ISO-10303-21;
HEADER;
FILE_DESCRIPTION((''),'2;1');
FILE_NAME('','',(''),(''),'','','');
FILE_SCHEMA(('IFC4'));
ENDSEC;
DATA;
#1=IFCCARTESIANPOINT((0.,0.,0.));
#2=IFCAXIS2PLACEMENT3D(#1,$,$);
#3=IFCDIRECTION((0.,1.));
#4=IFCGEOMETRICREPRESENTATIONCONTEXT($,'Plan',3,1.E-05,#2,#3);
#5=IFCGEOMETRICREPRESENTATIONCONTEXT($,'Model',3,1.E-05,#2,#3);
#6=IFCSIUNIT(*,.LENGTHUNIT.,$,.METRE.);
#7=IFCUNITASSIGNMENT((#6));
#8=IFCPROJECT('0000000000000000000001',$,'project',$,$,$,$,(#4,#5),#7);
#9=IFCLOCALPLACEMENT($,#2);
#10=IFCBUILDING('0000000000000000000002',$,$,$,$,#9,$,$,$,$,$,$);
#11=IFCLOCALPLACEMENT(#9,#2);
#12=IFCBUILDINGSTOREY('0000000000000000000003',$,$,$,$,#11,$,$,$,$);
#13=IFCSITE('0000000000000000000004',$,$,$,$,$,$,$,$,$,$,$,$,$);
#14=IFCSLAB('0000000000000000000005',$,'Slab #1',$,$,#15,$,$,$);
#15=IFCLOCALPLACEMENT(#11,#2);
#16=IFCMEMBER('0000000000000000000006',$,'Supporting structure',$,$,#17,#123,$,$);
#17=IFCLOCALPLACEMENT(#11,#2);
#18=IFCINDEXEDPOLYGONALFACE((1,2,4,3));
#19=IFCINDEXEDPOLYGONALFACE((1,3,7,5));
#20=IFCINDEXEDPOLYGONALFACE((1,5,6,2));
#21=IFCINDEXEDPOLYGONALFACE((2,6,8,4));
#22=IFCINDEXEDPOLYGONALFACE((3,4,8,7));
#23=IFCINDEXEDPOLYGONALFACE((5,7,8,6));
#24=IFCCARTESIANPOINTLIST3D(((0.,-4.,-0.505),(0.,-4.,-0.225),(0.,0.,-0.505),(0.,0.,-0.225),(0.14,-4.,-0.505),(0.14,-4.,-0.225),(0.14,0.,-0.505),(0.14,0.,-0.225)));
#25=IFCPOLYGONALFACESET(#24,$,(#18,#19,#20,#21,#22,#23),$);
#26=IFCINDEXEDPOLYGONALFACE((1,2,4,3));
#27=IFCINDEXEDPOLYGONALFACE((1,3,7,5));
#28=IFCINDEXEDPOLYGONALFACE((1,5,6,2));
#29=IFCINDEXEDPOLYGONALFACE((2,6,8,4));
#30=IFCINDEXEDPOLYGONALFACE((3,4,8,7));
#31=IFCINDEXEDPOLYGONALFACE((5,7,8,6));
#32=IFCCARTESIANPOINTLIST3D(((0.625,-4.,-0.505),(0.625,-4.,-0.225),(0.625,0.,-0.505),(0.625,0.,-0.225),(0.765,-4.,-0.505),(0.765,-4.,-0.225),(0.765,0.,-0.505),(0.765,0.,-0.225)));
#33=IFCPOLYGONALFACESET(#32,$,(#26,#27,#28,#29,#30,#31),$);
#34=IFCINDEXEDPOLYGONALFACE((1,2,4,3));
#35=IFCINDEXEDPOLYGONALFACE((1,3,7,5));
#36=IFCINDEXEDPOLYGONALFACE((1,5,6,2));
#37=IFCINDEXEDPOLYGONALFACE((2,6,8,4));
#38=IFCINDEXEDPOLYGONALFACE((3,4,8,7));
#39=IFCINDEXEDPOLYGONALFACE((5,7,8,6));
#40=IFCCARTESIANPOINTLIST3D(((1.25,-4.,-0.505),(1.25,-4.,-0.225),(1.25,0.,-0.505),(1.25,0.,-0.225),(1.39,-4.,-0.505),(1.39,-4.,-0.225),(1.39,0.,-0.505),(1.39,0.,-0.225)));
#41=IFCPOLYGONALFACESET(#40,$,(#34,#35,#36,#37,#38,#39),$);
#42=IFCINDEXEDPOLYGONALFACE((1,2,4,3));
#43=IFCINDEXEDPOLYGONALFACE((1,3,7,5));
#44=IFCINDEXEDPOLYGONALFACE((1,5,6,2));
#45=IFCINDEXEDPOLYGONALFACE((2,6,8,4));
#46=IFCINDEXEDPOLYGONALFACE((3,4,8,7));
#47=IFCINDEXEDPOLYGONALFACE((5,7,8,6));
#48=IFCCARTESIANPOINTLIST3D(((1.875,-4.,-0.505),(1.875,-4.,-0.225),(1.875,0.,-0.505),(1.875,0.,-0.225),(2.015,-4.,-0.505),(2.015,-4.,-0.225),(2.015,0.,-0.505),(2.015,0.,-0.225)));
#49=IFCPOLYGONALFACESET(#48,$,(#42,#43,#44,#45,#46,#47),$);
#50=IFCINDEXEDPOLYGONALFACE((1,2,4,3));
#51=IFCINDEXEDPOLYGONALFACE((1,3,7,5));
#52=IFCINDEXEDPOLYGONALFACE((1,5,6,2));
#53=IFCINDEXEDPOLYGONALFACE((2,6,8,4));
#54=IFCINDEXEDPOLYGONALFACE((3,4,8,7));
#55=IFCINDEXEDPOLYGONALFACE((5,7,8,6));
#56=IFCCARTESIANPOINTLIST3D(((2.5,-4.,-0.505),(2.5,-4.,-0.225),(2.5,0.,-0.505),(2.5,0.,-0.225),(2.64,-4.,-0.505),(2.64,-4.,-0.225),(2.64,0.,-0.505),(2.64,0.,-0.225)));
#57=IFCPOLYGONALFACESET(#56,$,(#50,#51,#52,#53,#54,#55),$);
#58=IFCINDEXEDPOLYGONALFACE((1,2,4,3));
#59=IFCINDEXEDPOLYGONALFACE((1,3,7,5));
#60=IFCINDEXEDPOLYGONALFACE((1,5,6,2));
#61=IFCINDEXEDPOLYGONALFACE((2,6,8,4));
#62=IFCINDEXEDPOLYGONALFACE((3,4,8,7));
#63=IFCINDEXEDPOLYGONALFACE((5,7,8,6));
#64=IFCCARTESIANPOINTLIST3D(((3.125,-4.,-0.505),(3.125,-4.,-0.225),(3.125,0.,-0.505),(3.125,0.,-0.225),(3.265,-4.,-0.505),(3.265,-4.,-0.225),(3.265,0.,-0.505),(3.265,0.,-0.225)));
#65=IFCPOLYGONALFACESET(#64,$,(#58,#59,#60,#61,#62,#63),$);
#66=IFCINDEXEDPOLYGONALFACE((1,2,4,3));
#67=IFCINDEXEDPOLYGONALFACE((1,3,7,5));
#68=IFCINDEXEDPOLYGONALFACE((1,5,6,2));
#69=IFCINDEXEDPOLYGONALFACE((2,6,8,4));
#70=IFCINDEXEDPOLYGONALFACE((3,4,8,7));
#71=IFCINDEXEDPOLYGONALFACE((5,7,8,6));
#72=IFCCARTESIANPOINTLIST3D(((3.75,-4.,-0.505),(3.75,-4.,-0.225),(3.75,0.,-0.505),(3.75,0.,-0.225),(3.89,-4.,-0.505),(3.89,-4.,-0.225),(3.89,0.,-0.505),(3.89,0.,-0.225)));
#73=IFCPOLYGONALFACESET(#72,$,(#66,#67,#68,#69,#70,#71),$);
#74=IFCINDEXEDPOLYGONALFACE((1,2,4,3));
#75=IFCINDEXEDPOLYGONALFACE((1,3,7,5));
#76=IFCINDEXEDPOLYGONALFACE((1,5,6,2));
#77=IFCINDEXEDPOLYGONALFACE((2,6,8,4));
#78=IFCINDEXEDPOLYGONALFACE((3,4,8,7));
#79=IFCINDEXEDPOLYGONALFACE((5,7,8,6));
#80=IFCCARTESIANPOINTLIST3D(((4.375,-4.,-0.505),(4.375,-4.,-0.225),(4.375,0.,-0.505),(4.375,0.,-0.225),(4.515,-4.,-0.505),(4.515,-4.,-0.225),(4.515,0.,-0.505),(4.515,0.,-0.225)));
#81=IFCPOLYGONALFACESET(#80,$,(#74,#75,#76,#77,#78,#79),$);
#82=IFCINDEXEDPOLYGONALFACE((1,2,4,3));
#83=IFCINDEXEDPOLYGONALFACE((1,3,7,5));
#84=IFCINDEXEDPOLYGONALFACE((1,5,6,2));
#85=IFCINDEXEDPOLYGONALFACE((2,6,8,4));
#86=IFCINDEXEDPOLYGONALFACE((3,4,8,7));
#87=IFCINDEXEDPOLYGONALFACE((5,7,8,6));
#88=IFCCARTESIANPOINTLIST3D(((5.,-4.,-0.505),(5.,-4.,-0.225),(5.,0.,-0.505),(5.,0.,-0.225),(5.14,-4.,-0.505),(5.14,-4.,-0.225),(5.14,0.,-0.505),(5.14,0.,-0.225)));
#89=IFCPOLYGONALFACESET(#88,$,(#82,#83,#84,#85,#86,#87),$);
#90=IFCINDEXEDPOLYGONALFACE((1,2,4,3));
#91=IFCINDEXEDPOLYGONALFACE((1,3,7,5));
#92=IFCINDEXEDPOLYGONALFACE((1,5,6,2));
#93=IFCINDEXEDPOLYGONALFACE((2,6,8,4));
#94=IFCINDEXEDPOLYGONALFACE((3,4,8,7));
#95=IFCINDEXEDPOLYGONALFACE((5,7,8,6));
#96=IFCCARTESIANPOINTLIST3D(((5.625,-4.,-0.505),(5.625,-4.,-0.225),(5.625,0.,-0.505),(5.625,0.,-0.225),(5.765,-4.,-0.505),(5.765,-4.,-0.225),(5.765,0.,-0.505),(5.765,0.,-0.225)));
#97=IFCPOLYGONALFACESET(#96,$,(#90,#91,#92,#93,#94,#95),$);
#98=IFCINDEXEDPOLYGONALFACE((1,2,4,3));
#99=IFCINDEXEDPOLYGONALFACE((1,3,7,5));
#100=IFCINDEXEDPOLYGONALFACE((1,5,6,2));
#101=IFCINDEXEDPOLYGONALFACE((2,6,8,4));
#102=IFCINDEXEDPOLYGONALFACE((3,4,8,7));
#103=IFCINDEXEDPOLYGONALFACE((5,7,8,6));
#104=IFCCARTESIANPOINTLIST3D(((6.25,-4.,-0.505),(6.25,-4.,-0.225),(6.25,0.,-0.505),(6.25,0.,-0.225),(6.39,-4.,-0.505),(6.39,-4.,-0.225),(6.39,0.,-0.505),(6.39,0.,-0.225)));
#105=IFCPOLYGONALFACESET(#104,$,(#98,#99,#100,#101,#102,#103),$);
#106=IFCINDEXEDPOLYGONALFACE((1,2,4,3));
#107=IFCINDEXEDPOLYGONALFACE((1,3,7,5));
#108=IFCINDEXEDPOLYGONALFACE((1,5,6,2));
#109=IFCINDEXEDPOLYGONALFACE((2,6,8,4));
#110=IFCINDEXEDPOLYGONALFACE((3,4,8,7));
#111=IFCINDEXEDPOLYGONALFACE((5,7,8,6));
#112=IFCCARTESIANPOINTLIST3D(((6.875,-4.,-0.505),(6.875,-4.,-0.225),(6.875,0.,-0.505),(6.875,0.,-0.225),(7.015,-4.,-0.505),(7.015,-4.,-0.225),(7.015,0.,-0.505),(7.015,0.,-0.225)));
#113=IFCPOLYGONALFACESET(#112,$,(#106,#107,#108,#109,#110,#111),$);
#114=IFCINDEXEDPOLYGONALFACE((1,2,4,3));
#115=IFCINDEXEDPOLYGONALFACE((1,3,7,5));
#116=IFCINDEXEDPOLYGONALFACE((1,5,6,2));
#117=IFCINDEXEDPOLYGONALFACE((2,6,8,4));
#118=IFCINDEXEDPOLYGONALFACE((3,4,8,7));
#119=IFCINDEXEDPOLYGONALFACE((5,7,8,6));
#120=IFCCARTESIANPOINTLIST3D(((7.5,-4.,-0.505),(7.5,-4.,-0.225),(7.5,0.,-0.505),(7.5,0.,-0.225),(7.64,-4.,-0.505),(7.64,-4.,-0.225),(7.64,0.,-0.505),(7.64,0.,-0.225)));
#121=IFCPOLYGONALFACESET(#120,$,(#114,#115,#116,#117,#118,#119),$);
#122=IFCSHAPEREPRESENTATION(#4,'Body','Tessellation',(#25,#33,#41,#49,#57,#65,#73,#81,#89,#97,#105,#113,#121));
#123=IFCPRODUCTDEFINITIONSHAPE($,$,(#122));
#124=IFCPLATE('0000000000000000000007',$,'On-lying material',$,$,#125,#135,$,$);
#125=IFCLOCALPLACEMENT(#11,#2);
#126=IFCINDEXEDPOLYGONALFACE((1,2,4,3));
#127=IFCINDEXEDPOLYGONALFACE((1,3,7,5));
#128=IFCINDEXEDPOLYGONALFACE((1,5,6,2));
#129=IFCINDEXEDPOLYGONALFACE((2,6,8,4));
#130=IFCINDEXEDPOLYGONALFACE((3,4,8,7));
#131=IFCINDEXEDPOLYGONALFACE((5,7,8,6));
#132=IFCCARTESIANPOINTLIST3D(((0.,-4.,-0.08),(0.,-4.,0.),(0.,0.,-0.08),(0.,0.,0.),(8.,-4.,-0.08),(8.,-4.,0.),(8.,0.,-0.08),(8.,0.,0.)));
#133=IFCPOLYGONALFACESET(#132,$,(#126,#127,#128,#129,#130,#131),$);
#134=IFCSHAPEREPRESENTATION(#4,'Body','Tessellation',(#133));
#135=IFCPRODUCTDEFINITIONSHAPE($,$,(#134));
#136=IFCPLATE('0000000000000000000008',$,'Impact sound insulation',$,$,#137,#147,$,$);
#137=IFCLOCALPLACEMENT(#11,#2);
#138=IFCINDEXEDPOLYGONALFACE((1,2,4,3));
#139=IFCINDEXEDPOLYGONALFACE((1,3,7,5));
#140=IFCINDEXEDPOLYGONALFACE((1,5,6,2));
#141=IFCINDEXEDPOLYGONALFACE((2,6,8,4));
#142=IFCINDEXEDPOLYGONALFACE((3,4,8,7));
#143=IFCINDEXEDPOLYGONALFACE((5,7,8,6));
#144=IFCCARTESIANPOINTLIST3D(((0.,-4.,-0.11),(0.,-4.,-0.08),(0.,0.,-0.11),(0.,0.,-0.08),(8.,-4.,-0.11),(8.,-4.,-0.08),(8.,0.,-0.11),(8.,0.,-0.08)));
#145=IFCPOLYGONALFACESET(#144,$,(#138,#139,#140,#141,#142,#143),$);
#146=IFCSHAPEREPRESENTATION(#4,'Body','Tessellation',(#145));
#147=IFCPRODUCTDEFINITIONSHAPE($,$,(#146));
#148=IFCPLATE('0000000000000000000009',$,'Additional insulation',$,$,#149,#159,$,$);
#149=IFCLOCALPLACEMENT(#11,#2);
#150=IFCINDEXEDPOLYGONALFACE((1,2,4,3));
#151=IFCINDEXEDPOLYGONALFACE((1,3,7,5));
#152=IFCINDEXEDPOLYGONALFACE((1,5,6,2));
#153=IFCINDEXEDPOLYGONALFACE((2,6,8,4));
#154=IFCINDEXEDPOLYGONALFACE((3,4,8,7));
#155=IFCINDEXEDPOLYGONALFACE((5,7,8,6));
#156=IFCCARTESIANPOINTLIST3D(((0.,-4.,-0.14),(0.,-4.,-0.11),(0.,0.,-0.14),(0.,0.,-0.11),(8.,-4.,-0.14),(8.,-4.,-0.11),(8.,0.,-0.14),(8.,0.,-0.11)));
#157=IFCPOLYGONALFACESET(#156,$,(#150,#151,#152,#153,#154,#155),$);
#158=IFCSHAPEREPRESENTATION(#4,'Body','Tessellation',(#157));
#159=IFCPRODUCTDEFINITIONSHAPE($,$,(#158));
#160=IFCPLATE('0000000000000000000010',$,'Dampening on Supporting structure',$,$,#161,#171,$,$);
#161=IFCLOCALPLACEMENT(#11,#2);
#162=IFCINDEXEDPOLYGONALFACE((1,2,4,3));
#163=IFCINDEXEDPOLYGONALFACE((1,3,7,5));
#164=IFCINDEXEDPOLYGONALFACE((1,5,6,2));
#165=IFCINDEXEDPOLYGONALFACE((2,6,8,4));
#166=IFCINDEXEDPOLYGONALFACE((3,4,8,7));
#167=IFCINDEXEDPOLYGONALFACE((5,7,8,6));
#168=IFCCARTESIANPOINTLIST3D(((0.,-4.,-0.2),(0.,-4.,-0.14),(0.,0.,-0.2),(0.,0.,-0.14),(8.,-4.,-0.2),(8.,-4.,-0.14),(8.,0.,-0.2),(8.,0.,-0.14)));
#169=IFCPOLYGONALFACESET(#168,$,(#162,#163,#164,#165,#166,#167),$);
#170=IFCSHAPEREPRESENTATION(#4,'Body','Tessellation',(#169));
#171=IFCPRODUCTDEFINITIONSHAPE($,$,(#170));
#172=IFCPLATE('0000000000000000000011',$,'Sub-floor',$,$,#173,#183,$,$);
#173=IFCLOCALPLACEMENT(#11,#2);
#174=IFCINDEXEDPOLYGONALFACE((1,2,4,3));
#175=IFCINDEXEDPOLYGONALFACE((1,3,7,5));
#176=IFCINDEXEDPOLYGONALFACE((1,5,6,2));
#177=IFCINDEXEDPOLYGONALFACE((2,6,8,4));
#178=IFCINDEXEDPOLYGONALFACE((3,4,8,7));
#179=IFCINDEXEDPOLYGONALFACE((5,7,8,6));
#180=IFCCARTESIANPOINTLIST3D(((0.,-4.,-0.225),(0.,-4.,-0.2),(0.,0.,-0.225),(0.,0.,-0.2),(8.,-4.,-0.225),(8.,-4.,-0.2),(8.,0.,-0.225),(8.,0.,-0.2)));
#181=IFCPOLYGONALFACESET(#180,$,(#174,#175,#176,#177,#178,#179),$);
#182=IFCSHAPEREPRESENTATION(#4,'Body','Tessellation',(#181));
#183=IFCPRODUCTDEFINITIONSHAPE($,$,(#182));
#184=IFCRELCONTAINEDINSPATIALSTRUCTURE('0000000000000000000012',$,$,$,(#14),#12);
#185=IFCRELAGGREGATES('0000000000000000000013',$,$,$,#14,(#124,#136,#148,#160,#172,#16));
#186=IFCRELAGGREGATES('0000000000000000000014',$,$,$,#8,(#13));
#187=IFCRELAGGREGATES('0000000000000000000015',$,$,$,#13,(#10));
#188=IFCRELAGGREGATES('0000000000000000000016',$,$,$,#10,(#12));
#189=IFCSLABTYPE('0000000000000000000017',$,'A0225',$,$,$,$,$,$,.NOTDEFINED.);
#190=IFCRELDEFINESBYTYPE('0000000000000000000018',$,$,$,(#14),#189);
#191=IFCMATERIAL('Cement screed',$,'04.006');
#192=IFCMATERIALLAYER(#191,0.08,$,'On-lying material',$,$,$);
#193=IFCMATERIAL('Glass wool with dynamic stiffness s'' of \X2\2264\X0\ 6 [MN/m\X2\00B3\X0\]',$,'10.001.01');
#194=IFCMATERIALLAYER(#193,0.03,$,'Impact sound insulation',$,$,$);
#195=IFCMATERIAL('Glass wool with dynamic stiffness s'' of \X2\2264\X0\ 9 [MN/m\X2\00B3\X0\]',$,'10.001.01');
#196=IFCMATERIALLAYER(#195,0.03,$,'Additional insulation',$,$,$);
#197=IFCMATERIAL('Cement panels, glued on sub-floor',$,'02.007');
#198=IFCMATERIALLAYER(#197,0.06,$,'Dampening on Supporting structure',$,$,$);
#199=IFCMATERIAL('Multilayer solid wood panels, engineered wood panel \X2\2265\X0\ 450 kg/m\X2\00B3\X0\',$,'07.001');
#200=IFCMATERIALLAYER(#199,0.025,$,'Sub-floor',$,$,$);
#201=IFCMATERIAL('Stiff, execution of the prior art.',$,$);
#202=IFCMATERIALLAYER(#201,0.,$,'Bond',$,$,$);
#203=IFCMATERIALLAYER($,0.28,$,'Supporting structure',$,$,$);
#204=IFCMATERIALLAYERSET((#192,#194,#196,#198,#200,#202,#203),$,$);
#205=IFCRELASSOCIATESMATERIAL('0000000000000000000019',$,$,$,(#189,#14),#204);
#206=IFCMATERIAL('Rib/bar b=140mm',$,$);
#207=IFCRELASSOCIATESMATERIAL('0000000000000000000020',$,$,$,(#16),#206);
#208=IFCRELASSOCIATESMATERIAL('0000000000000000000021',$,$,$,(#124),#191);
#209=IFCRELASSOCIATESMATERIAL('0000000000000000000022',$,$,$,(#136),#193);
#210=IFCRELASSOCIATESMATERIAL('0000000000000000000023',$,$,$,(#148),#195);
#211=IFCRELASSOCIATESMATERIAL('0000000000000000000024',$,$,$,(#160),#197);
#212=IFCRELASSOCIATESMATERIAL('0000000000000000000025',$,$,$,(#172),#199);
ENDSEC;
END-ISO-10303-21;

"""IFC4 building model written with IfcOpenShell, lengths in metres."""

from ifc_helpers import new_model, si_unit, direction, frame, frame_2d, origin, origin_with_axes, place, context, project, spatial, rectangle, extrude, material, layer, layer_set, type_object, element, aggregate, save


model = new_model("IFC4")

# Units and contexts
plan_context = context("Plan", 3, precision=1e-05, world=origin(), true_north=direction((0.0, 1.0)))
model_context = context("Model", 3, precision=1e-05, world=origin(), true_north=direction((0.0, 1.0)))
ifc_project = project(units=[si_unit("LENGTHUNIT", "METRE")], contexts=[plan_context, model_context])

# Site, building, storey
site = spatial("IfcSite", under=ifc_project)
building_placement = place(None, origin())
building = spatial("IfcBuilding", under=site, at=building_placement)
storey_placement = place(building_placement, origin())
storey = spatial("IfcBuildingStorey", under=building, at=storey_placement)

# Slab, member, plates
ifc_material_1 = material(Name="Cement screed", Category="04.006")
ifc_layer_1 = layer(ifc_material_1, 0.08, Name="On-lying material")
ifc_material_2 = material(Name="Glass wool with dynamic stiffness s' of ≤ 6 [MN/m³]", Category="10.001.01")
ifc_layer_2 = layer(ifc_material_2, 0.03, Name="Impact sound insulation")
ifc_material_3 = material(Name="Glass wool with dynamic stiffness s' of ≤ 9 [MN/m³]", Category="10.001.01")
ifc_layer_3 = layer(ifc_material_3, 0.03, Name="Additional insulation")
ifc_material_4 = material(Name="Cement panels, glued on sub-floor", Category="02.007")
ifc_layer_4 = layer(ifc_material_4, 0.06, Name="Dampening on Supporting structure")
ifc_material_5 = material(Name="Multilayer solid wood panels, engineered wood panel ≥ 450 kg/m³", Category="07.001")
ifc_layer_5 = layer(ifc_material_5, 0.025, Name="Sub-floor")
ifc_material_6 = material(Name="Stiff, execution of the prior art.")
ifc_layer_6 = layer(ifc_material_6, 0.0, Name="Bond")
ifc_layer_7 = layer(None, 0.28, Name="Supporting structure")
ifc_layer_set = layer_set([ifc_layer_1, ifc_layer_2, ifc_layer_3, ifc_layer_4, ifc_layer_5, ifc_layer_6, ifc_layer_7])
slab_type = type_object("IfcSlabType", Name="A0225", PredefinedType="NOTDEFINED", material=ifc_layer_set)
slab_placement = place(None, frame((0.0, 0.0, 0.0), z_axis=(0.0, 0.0, -1.0), x_axis=(1.0, 0.0, 0.0)))
slab = element("IfcSlab", 1, at=slab_placement, inside=storey, type_object=slab_type, material=ifc_layer_set, Name="Slab #1")
ifc_material_7 = material(Name="Rib/bar b=140mm")
member_placement = place(slab_placement, origin())
member = element("IfcMember", 2, at=member_placement, material=ifc_material_7, Name="Supporting structure", context=plan_context, shape_type="SweptSolid", body=[
    extrude(rectangle(XDim=0.14, YDim=0.28, at=frame_2d((0.07, 0.14), x_axis=(1.0, 0.0))), frame((0.0, 4.0, 0.225), z_axis=(0.0, -1.0, 0.0), x_axis=(1.0, 0.0, 0.0)), (0.0, 0.0, 1.0), 4.0),
    extrude(rectangle(XDim=0.14, YDim=0.28, at=frame_2d((0.07, 0.14), x_axis=(1.0, 0.0))), frame((0.625, 4.0, 0.225), z_axis=(0.0, -1.0, 0.0), x_axis=(1.0, 0.0, 0.0)), (0.0, 0.0, 1.0), 4.0),
    extrude(rectangle(XDim=0.14, YDim=0.28, at=frame_2d((0.07, 0.14), x_axis=(1.0, 0.0))), frame((1.25, 4.0, 0.225), z_axis=(0.0, -1.0, 0.0), x_axis=(1.0, 0.0, 0.0)), (0.0, 0.0, 1.0), 4.0),
    extrude(rectangle(XDim=0.14, YDim=0.28, at=frame_2d((0.07, 0.14), x_axis=(1.0, 0.0))), frame((1.875, 4.0, 0.225), z_axis=(0.0, -1.0, 0.0), x_axis=(1.0, 0.0, 0.0)), (0.0, 0.0, 1.0), 4.0),
    extrude(rectangle(XDim=0.14, YDim=0.28, at=frame_2d((0.07, 0.14), x_axis=(1.0, 0.0))), frame((2.5, 4.0, 0.225), z_axis=(0.0, -1.0, 0.0), x_axis=(1.0, 0.0, 0.0)), (0.0, 0.0, 1.0), 4.0),
    extrude(rectangle(XDim=0.14, YDim=0.28, at=frame_2d((0.07, 0.14), x_axis=(1.0, 0.0))), frame((3.125, 4.0, 0.225), z_axis=(0.0, -1.0, 0.0), x_axis=(1.0, 0.0, 0.0)), (0.0, 0.0, 1.0), 4.0),
    extrude(rectangle(XDim=0.14, YDim=0.28, at=frame_2d((0.07, 0.14), x_axis=(1.0, 0.0))), frame((3.75, 4.0, 0.225), z_axis=(0.0, -1.0, 0.0), x_axis=(1.0, 0.0, 0.0)), (0.0, 0.0, 1.0), 4.0),
    extrude(rectangle(XDim=0.14, YDim=0.28, at=frame_2d((0.07, 0.14), x_axis=(1.0, 0.0))), frame((4.375, 4.0, 0.225), z_axis=(0.0, -1.0, 0.0), x_axis=(1.0, 0.0, 0.0)), (0.0, 0.0, 1.0), 4.0),
    extrude(rectangle(XDim=0.14, YDim=0.28, at=frame_2d((0.07, 0.14), x_axis=(1.0, 0.0))), frame((5.0, 4.0, 0.225), z_axis=(0.0, -1.0, 0.0), x_axis=(1.0, 0.0, 0.0)), (0.0, 0.0, 1.0), 4.0),
    extrude(rectangle(XDim=0.14, YDim=0.28, at=frame_2d((0.07, 0.14), x_axis=(1.0, 0.0))), frame((5.625, 4.0, 0.225), z_axis=(0.0, -1.0, 0.0), x_axis=(1.0, 0.0, 0.0)), (0.0, 0.0, 1.0), 4.0),
    extrude(rectangle(XDim=0.14, YDim=0.28, at=frame_2d((0.07, 0.14), x_axis=(1.0, 0.0))), frame((6.25, 4.0, 0.225), z_axis=(0.0, -1.0, 0.0), x_axis=(1.0, 0.0, 0.0)), (0.0, 0.0, 1.0), 4.0),
    extrude(rectangle(XDim=0.14, YDim=0.28, at=frame_2d((0.07, 0.14), x_axis=(1.0, 0.0))), frame((6.875, 4.0, 0.225), z_axis=(0.0, -1.0, 0.0), x_axis=(1.0, 0.0, 0.0)), (0.0, 0.0, 1.0), 4.0),
    extrude(rectangle(XDim=0.14, YDim=0.28, at=frame_2d((0.07, 0.14), x_axis=(1.0, 0.0))), frame((7.5, 4.0, 0.225), z_axis=(0.0, -1.0, 0.0), x_axis=(1.0, 0.0, 0.0)), (0.0, 0.0, 1.0), 4.0),
])
plate_1_placement = place(slab_placement, origin())
plate_1 = element("IfcPlate", 3, at=plate_1_placement, material=ifc_material_1, Name="On-lying material", context=plan_context, shape_type="SweptSolid", body=[
    extrude(rectangle(XDim=8.0, YDim=4.0, at=frame_2d((4.0, 2.0), x_axis=(1.0, 0.0))), origin_with_axes(), (0.0, 0.0, 1.0), 0.08),
])
plate_2_placement = place(slab_placement, origin())
plate_2 = element("IfcPlate", 4, at=plate_2_placement, material=ifc_material_2, Name="Impact sound insulation", context=plan_context, shape_type="SweptSolid", body=[
    extrude(rectangle(XDim=8.0, YDim=4.0, at=frame_2d((4.0, 2.0), x_axis=(1.0, 0.0))), frame((0.0, 0.0, 0.08), z_axis=(0.0, 0.0, 1.0), x_axis=(1.0, 0.0, 0.0)), (0.0, 0.0, 1.0), 0.03),
])
plate_3_placement = place(slab_placement, origin())
plate_3 = element("IfcPlate", 5, at=plate_3_placement, material=ifc_material_3, Name="Additional insulation", context=plan_context, shape_type="SweptSolid", body=[
    extrude(rectangle(XDim=8.0, YDim=4.0, at=frame_2d((4.0, 2.0), x_axis=(1.0, 0.0))), frame((0.0, 0.0, 0.11), z_axis=(0.0, 0.0, 1.0), x_axis=(1.0, 0.0, 0.0)), (0.0, 0.0, 1.0), 0.03),
])
plate_4_placement = place(slab_placement, origin())
plate_4 = element("IfcPlate", 6, at=plate_4_placement, material=ifc_material_4, Name="Dampening on Supporting structure", context=plan_context, shape_type="SweptSolid", body=[
    extrude(rectangle(XDim=8.0, YDim=4.0, at=frame_2d((4.0, 2.0), x_axis=(1.0, 0.0))), frame((0.0, 0.0, 0.14), z_axis=(0.0, 0.0, 1.0), x_axis=(1.0, 0.0, 0.0)), (0.0, 0.0, 1.0), 0.06),
])
plate_5_placement = place(slab_placement, origin())
plate_5 = element("IfcPlate", 7, at=plate_5_placement, material=ifc_material_5, Name="Sub-floor", context=plan_context, shape_type="SweptSolid", body=[
    extrude(rectangle(XDim=8.0, YDim=4.0, at=frame_2d((4.0, 2.0), x_axis=(1.0, 0.0))), frame((0.0, 0.0, 0.2), z_axis=(0.0, 0.0, 1.0), x_axis=(1.0, 0.0, 0.0)), (0.0, 0.0, 1.0), 0.025),
])
aggregate(slab, [plate_1, plate_2, plate_3, plate_4, plate_5, member])

save(model, "model.ifc")
